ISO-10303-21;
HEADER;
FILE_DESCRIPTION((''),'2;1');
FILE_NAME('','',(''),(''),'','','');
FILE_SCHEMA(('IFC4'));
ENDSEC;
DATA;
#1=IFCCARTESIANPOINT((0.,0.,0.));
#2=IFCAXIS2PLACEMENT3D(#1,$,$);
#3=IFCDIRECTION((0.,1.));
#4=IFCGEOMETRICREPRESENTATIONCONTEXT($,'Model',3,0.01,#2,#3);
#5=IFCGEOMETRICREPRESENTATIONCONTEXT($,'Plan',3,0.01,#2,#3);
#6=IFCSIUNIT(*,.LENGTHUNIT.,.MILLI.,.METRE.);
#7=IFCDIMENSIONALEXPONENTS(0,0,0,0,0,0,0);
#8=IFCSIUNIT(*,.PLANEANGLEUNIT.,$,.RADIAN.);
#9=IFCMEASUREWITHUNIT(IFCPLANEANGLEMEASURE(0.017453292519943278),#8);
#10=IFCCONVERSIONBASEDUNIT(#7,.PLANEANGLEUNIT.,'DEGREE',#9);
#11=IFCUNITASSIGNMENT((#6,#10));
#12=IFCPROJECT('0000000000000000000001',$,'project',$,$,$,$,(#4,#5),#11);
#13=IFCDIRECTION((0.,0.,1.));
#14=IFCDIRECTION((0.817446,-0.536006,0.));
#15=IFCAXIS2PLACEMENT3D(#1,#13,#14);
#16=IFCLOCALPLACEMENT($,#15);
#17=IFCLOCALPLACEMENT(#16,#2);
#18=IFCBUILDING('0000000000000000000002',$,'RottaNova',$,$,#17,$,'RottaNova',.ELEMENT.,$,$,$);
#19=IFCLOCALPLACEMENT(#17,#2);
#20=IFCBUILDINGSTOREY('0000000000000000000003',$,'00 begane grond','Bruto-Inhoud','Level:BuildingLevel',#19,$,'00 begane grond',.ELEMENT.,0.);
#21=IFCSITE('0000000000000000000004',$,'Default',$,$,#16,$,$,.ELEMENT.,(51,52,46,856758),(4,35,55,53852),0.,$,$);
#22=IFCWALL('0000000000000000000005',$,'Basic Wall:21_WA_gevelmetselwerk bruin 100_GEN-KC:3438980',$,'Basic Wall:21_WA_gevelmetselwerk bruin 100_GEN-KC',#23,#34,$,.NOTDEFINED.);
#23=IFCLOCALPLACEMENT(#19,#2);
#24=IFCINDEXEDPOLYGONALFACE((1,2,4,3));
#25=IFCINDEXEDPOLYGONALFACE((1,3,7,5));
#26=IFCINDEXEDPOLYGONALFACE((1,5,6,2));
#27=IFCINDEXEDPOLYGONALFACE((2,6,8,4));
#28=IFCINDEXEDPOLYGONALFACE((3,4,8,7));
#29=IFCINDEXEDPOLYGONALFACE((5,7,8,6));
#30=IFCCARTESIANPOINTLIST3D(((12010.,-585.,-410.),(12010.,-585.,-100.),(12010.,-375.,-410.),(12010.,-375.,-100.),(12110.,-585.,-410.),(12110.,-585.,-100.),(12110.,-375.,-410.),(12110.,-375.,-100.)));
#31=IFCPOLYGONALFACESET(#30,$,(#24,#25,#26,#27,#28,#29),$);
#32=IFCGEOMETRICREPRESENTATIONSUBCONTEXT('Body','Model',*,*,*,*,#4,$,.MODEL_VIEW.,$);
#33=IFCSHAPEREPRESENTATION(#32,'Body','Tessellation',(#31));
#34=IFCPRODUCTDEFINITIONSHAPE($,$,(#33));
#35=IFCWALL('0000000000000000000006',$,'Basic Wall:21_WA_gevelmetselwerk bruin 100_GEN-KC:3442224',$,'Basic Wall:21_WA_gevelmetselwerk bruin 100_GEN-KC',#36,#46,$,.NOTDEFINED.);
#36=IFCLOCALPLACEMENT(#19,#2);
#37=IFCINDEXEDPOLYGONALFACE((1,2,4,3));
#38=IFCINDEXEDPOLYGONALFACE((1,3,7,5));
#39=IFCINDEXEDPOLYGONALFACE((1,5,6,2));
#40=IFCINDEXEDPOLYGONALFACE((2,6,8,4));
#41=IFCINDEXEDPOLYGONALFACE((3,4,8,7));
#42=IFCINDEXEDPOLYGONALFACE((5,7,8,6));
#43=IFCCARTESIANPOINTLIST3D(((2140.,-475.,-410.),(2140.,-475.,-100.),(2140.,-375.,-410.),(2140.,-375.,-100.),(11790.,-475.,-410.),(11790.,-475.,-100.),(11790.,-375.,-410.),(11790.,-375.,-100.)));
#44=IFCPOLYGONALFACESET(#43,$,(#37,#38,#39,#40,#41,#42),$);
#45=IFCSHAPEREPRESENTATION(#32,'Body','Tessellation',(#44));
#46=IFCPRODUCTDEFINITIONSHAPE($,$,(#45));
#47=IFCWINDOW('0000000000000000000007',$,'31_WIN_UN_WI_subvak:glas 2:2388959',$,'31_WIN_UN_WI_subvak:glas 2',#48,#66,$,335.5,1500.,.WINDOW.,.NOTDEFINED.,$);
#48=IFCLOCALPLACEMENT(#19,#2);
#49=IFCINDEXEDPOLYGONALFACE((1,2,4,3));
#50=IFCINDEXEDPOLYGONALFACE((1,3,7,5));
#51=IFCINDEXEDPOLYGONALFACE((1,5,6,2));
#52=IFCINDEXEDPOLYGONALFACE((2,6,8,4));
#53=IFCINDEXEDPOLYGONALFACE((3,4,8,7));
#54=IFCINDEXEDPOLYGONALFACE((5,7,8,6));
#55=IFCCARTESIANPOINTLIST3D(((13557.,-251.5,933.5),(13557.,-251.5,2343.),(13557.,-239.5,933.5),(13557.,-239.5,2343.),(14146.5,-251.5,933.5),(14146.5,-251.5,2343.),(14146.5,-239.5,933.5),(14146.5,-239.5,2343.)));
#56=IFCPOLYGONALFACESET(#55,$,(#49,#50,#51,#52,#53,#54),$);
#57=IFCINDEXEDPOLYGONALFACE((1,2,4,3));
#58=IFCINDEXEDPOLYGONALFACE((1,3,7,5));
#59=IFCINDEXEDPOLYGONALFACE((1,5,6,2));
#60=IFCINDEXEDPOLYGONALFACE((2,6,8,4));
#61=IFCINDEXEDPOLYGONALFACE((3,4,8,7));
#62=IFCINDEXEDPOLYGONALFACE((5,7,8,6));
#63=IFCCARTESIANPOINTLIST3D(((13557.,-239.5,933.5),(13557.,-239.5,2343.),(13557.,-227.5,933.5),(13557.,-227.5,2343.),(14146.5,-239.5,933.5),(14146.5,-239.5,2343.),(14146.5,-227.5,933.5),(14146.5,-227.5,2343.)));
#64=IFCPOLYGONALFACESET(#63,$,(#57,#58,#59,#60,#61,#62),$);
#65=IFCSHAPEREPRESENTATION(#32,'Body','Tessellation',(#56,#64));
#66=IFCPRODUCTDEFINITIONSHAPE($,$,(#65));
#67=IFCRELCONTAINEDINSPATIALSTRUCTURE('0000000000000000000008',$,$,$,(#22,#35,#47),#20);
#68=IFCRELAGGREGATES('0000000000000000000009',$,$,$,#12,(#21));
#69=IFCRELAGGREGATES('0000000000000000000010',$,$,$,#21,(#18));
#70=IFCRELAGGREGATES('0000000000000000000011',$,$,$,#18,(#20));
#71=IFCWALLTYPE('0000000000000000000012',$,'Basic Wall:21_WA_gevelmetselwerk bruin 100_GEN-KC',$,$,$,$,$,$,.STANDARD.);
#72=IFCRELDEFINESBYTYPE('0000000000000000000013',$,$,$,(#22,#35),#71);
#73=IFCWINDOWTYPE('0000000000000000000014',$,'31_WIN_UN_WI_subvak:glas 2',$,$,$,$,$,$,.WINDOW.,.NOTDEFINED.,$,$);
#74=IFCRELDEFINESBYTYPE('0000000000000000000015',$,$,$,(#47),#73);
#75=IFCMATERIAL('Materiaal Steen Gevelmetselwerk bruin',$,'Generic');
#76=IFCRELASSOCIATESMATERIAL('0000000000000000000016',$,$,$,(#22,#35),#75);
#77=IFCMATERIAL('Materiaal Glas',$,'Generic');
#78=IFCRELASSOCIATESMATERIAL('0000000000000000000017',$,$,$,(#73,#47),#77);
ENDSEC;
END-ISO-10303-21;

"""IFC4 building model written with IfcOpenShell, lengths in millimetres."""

from ifc_helpers import new_model, entity, si_unit, converted_unit, direction, frame, origin, place, context, subcontext, project, spatial, indexed_curve, outline, extrude, source, transform, mapped, material, type_object, type_shapes, element, save


model = new_model("IFC4")

# Units and contexts
model_context = context("Model", 3, precision=0.01, world=origin(), true_north=direction((0.0, 1.0)))
plan_context = context("Plan", 3, precision=0.01, world=origin(), true_north=direction((0.0, 1.0)))
body_context = subcontext(model_context, "Body", "Model", "MODEL_VIEW")
ifc_project = project(units=[si_unit("LENGTHUNIT", "METRE", prefix="MILLI"), converted_unit("PLANEANGLEUNIT", "DEGREE", entity("IfcPlaneAngleMeasure", 0.017453292519943278), si_unit("PLANEANGLEUNIT", "RADIAN"), dimensions=[0, 0, 0, 0, 0, 0, 0])], contexts=[model_context, plan_context])

# Site, building, storey
site_placement = place(None, frame((0.0, 0.0, 0.0), z_axis=(0.0, 0.0, 1.0), x_axis=(0.817446, -0.536006, 0.0)))
site = spatial("IfcSite", under=ifc_project, at=site_placement, Name="Default", CompositionType="ELEMENT", RefLatitude=(51, 52, 46, 856758), RefLongitude=(4, 35, 55, 53852), RefElevation=0.0)
building_placement = place(site_placement, origin())
building = spatial("IfcBuilding", under=site, at=building_placement, Name="RottaNova", LongName="RottaNova", CompositionType="ELEMENT")
storey_placement = place(building_placement, origin())
storey = spatial("IfcBuildingStorey", under=building, at=storey_placement, Name="00 begane grond", Description="Bruto-Inhoud", ObjectType="Level:BuildingLevel", LongName="00 begane grond", CompositionType="ELEMENT", Elevation=0.0)

# Shared definitions
ifc_material_1 = material(Name="Materiaal Glas", Category="Generic")

# Walls
ifc_material_2 = material(Name="Materiaal Steen Gevelmetselwerk bruin", Category="Generic")
wall_type_1 = type_object("IfcWallType", Name="Basic Wall:21_WA_gevelmetselwerk bruin 100_GEN-KC", PredefinedType="STANDARD")
wall_1_placement = place(storey_placement, frame((12060.0, -585.0, -410.0), z_axis=(0.0, 0.0, 1.0), x_axis=(0.0, 1.0, 0.0)))
element("IfcWall", 1, at=wall_1_placement, inside=storey, type_object=wall_type_1, material=ifc_material_2, Name="Basic Wall:21_WA_gevelmetselwerk bruin 100_GEN-KC:3438980", ObjectType="Basic Wall:21_WA_gevelmetselwerk bruin 100_GEN-KC", PredefinedType="NOTDEFINED", context=body_context, shape_type="SweptSolid", body=[
    extrude(outline(indexed_curve([(210.0, 50.0), (0.0, 50.0), (0.0, -50.0), (210.0, -50.0), (210.0, 50.0)], self_intersect=False)), origin(), (0.0, 0.0, 1.0), 310.0),
])
wall_2_placement = place(storey_placement, frame((11790.0, -425.0, -410.0), z_axis=(0.0, 0.0, 1.0), x_axis=(-1.0, 0.0, 0.0)))
element("IfcWall", 2, at=wall_2_placement, inside=storey, type_object=wall_type_1, material=ifc_material_2, Name="Basic Wall:21_WA_gevelmetselwerk bruin 100_GEN-KC:3442224", ObjectType="Basic Wall:21_WA_gevelmetselwerk bruin 100_GEN-KC", PredefinedType="NOTDEFINED", context=body_context, shape_type="SweptSolid", body=[
    extrude(outline(indexed_curve([(9650.0, 50.0), (0.0, 50.0), (0.0, -50.0), (9650.0, -50.0), (9650.0, 50.0)], self_intersect=False)), origin(), (0.0, 0.0, 1.0), 310.0),
])

# Window
window_type = type_object("IfcWindowType", Name="31_WIN_UN_WI_subvak:glas 2", PartitioningType="NOTDEFINED", PredefinedType="WINDOW", material=ifc_material_1)
shared_shape_1 = source(origin(), body_context, "Body", "SweptSolid", [
    extrude(outline(indexed_curve([(-6.0, -294.7), (6.0, -294.7), (6.0, 294.7), (-6.0, 294.7), (-6.0, -294.7)], self_intersect=False)), frame((0.0, 6.0, 0.0), z_axis=(0.0, 0.0, 1.0), x_axis=(0.0, -1.0, 0.0)), (0.0, 0.0, 1.0), 1409.5),
    extrude(outline(indexed_curve([(-6.0, -294.8), (6.0, -294.8), (6.0, 294.8), (-6.0, 294.8), (-6.0, -294.8)], self_intersect=False)), frame((0.0, -6.0, 0.0), z_axis=(0.0, 0.0, 1.0), x_axis=(0.0, -1.0, 0.0)), (0.0, 0.0, 1.0), 1409.5),
])
type_shapes(window_type, [shared_shape_1])
window_1_placement = place(storey_placement, frame((13851.8, -239.5, 933.5), z_axis=(0.0, 0.0, 1.0), x_axis=(-1.0, 0.0, 0.0)))
element("IfcWindow", 3, at=window_1_placement, inside=storey, type_object=window_type, material=ifc_material_1, Name="31_WIN_UN_WI_subvak:glas 2:2388959", ObjectType="31_WIN_UN_WI_subvak:glas 2", OverallHeight=335.5, OverallWidth=1500.0, PartitioningType="NOTDEFINED", PredefinedType="WINDOW", context=body_context, shape_type="MappedRepresentation", body=[
    mapped(shared_shape_1, transform((0.0, 0.0, 0.0), scale=1.0)),
])

save(model, "model.ifc")
